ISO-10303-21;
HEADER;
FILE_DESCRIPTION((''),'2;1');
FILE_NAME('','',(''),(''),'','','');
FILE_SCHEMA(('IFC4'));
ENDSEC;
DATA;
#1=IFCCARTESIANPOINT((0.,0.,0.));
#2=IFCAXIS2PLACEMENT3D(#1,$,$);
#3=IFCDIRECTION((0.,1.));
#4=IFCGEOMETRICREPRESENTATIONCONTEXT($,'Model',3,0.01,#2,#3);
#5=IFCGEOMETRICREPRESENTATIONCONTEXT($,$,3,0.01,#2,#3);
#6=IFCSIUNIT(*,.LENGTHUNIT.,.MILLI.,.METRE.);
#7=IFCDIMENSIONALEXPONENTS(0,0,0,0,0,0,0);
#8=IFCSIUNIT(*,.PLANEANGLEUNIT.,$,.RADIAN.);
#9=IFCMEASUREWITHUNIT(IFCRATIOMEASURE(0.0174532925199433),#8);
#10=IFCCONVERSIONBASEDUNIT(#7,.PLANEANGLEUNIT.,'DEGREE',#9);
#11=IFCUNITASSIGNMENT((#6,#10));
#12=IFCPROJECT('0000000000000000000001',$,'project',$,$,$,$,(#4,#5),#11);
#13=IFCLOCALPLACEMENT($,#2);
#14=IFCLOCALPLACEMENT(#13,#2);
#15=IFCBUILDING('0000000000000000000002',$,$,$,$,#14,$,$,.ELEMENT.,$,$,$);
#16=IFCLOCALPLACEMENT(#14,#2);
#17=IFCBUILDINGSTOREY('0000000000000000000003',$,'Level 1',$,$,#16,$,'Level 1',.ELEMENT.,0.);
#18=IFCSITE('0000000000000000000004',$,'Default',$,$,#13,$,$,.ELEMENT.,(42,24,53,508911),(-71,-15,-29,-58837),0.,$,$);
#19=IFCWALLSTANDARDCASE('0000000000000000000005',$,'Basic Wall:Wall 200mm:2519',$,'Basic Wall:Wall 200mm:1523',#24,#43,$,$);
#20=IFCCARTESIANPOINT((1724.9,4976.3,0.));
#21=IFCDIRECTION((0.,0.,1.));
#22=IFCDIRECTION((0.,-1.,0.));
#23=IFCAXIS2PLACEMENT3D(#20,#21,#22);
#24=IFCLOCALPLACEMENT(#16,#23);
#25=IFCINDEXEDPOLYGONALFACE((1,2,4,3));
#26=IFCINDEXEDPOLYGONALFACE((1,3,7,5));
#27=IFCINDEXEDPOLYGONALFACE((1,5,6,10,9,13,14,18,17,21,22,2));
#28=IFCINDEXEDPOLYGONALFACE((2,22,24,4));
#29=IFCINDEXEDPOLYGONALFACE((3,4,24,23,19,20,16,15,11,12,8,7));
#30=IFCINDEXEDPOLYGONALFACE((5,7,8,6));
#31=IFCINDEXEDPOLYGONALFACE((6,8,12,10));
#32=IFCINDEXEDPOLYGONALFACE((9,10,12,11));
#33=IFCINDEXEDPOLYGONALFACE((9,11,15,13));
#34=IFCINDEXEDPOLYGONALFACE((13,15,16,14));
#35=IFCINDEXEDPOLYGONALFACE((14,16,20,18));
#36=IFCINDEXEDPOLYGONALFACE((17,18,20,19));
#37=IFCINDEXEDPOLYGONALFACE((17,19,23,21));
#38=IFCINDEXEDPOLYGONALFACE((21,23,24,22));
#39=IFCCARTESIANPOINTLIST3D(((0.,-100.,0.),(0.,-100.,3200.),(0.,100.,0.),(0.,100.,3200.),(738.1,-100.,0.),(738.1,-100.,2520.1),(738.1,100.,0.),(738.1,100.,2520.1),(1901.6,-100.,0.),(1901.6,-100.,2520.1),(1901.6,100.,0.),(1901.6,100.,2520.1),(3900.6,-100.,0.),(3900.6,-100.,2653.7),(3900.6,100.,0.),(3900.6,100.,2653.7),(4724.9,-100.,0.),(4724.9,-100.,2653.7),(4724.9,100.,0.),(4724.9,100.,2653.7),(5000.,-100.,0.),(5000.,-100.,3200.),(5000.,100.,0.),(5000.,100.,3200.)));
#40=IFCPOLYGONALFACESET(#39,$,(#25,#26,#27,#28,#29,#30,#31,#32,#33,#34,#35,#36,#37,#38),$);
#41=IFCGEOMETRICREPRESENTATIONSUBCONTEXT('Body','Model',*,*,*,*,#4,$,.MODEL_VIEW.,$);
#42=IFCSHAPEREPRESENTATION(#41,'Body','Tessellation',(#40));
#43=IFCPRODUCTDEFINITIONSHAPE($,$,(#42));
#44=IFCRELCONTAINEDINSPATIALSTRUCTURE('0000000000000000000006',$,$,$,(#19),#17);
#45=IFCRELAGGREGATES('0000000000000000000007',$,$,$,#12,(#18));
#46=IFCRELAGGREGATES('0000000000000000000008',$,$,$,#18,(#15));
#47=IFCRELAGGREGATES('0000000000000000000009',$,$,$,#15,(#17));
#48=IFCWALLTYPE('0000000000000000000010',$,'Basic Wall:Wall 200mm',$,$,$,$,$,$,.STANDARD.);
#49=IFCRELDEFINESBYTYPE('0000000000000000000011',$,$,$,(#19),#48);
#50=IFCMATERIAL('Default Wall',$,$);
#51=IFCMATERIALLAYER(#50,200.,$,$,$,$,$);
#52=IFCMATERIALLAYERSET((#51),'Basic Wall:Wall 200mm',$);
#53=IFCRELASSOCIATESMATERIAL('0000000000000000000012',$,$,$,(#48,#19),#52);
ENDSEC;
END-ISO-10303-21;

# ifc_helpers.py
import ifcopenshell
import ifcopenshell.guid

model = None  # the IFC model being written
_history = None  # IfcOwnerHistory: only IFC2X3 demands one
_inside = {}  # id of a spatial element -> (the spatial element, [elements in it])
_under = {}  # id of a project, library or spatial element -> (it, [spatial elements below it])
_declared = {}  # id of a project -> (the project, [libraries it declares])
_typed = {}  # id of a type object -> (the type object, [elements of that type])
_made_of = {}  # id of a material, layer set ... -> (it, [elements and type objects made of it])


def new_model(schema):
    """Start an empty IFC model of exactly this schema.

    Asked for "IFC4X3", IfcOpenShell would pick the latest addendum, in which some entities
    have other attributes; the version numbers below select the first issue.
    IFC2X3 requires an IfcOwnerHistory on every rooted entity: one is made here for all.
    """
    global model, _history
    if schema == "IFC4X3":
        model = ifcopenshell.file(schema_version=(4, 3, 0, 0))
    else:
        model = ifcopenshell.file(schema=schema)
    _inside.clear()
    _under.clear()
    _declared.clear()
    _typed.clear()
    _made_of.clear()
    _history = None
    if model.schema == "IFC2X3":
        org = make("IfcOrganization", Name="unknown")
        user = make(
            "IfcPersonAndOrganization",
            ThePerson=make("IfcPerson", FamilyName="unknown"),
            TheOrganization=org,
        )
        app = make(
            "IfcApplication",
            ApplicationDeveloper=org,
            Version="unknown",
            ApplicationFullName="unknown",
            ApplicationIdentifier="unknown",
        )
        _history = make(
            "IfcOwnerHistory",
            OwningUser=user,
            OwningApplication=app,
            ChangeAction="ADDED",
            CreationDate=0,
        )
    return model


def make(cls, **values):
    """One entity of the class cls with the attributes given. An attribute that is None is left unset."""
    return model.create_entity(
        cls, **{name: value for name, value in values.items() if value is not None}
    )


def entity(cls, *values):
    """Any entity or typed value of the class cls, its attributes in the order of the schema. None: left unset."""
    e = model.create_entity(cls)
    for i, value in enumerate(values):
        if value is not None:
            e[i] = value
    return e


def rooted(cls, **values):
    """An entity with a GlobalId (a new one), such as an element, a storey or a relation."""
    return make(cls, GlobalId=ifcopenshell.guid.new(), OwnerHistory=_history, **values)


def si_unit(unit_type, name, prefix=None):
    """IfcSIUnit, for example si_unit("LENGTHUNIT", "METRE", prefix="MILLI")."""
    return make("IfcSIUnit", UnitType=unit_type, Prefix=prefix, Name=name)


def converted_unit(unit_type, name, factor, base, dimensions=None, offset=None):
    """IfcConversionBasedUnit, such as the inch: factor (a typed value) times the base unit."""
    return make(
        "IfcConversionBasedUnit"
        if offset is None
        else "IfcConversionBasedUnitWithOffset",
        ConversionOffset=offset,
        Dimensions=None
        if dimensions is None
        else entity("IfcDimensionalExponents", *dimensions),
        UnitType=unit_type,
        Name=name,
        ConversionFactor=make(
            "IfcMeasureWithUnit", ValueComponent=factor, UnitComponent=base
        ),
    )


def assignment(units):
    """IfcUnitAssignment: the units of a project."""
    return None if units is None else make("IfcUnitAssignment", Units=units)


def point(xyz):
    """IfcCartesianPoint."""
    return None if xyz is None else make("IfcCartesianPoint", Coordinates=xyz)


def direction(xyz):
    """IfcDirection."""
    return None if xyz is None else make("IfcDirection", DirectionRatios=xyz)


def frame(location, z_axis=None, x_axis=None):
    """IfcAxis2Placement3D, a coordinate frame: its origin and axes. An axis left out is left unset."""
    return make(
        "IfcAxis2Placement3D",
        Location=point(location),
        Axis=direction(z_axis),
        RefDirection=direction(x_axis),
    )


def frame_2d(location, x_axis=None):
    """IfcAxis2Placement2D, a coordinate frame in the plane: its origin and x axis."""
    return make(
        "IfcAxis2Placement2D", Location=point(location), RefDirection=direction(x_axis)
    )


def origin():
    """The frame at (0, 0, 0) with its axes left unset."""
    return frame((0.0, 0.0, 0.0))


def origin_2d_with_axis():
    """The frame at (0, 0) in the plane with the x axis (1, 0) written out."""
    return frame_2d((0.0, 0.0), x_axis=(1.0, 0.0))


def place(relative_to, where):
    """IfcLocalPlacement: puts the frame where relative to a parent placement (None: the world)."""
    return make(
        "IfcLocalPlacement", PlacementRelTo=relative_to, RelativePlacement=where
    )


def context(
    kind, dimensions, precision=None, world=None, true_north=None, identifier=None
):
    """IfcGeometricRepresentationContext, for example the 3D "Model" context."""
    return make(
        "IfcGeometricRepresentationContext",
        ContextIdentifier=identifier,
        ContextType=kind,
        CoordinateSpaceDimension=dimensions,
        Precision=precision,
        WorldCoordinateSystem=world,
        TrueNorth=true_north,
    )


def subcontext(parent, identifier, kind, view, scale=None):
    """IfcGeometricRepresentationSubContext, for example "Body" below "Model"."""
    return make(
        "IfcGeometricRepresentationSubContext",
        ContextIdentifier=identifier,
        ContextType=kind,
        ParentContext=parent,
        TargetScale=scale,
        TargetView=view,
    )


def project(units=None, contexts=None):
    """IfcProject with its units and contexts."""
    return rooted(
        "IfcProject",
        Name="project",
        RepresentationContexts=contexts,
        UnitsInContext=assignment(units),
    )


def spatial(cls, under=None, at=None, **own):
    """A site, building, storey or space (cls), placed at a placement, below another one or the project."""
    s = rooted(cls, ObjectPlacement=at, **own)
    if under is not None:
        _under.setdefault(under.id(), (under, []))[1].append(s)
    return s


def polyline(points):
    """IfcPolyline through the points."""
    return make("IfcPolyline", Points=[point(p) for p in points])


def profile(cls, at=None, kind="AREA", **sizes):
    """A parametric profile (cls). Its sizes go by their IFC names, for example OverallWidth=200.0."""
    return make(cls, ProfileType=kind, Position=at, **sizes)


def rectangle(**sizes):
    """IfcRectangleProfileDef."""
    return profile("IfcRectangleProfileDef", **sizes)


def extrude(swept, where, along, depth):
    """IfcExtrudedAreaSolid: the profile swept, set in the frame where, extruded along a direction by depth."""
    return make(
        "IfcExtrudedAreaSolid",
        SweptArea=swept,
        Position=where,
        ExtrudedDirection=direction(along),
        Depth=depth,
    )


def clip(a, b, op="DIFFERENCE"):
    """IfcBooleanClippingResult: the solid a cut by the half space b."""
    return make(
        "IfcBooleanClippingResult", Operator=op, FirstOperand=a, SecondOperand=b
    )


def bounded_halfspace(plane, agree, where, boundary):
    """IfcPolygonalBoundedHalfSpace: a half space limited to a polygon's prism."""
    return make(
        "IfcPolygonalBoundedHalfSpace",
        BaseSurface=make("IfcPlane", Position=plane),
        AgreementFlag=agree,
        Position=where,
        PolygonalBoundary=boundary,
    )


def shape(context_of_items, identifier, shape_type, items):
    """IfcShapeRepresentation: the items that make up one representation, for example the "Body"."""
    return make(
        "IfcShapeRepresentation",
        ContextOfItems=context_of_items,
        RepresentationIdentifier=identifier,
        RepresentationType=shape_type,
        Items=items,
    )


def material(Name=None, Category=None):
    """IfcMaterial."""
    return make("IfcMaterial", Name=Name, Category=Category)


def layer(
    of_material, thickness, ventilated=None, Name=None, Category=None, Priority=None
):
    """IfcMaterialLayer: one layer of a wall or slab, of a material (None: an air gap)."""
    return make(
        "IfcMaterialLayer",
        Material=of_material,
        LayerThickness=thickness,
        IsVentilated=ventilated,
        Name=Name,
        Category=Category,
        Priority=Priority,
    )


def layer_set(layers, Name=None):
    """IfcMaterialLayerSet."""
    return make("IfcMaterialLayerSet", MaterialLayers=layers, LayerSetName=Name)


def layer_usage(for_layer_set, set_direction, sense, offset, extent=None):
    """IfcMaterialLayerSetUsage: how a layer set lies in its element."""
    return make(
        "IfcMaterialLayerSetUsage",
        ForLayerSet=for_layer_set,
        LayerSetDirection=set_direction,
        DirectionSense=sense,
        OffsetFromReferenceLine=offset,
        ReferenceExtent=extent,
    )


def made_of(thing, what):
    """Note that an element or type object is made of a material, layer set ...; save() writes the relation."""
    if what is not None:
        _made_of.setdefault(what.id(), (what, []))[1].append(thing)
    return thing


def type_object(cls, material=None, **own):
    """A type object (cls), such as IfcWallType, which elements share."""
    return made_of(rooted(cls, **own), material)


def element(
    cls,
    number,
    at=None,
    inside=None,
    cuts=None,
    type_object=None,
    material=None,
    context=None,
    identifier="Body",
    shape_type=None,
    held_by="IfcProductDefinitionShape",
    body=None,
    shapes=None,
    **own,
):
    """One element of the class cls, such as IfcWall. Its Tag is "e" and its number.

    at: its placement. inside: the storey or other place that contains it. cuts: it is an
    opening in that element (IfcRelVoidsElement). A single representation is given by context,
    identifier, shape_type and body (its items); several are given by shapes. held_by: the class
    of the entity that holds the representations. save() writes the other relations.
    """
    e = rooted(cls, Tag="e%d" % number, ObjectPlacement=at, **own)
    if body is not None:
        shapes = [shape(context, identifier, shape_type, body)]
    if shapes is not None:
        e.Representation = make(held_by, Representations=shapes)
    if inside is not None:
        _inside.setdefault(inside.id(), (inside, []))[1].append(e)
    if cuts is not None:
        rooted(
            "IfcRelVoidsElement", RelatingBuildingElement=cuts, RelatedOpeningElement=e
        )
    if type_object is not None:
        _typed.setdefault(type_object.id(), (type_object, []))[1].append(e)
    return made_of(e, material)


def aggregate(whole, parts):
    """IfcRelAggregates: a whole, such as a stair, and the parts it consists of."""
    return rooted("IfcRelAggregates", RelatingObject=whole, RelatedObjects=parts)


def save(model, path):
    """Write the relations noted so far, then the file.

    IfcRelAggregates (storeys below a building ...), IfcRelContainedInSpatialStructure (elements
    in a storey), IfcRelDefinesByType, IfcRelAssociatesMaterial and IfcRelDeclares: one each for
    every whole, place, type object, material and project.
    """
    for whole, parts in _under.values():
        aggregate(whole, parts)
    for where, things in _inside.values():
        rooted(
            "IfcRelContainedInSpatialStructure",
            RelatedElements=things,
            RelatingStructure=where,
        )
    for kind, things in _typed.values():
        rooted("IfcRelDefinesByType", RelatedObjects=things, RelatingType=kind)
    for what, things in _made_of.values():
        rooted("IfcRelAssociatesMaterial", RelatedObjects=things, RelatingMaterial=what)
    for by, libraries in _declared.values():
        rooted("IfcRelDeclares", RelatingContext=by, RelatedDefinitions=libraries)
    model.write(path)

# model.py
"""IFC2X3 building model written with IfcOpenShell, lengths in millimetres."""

from ifc_helpers import new_model, entity, si_unit, converted_unit, direction, frame, frame_2d, origin, origin_2d_with_axis, place, context, subcontext, project, spatial, polyline, rectangle, extrude, clip, bounded_halfspace, material, layer, layer_set, layer_usage, type_object, element, save


model = new_model("IFC2X3")

# Units and contexts
model_context = context("Model", 3, precision=0.01, world=origin(), true_north=direction((0.0, 1.0)))
context_of_model = context(None, 3, precision=0.01, world=origin(), true_north=direction((0.0, 1.0)))
body_context = subcontext(model_context, "Body", "Model", "MODEL_VIEW")
ifc_project = project(units=[si_unit("LENGTHUNIT", "METRE", prefix="MILLI"), converted_unit("PLANEANGLEUNIT", "DEGREE", entity("IfcRatioMeasure", 0.0174532925199433), si_unit("PLANEANGLEUNIT", "RADIAN"), dimensions=[0, 0, 0, 0, 0, 0, 0])], contexts=[model_context, context_of_model])

# Site, building, storey
site_placement = place(None, origin())
site = spatial("IfcSite", under=ifc_project, at=site_placement, Name="Default", CompositionType="ELEMENT", RefLatitude=(42, 24, 53, 508911), RefLongitude=(-71, -15, -29, -58837), RefElevation=0.0)
building_placement = place(site_placement, origin())
building = spatial("IfcBuilding", under=site, at=building_placement, CompositionType="ELEMENT")
storey_placement = place(building_placement, origin())
storey = spatial("IfcBuildingStorey", under=building, at=storey_placement, Name="Level 1", LongName="Level 1", CompositionType="ELEMENT", Elevation=0.0)

# Shared definitions
ifc_material_1 = material(Name="Default Wall")
ifc_layer_1 = layer(ifc_material_1, 200.0)
ifc_layer_set_1 = layer_set([ifc_layer_1], Name="Basic Wall:Wall 200mm")
wall_type = type_object("IfcWallType", Name="Basic Wall:Wall 200mm", PredefinedType="STANDARD", material=ifc_layer_set_1)

# Wall, openings
ifc_layer_usage_1 = layer_usage(ifc_layer_set_1, "AXIS2", "NEGATIVE", 100.0)
wall_1_placement = place(storey_placement, frame((1724.9, 4976.3, 0.0), z_axis=(0.0, 0.0, 1.0), x_axis=(0.0, -1.0, 0.0)))
wall_1 = element("IfcWallStandardCase", 1, at=wall_1_placement, inside=storey, type_object=wall_type, material=ifc_layer_usage_1, Name="Basic Wall:Wall 200mm:2519", ObjectType="Basic Wall:Wall 200mm:1523", context=body_context, shape_type="Clipping", body=[
    clip(extrude(rectangle(XDim=5000.0, YDim=200.0, at=frame_2d((2500.0, 0.0), x_axis=(-1.0, 0.0))), origin(), (0.0, 0.0, 1.0), 3200.0), bounded_halfspace(frame((0.0, -100.0, 3200.0), z_axis=(0.0, 0.0, -1.0), x_axis=(0.0, 1.0, 0.0)), True, frame((0.0, -100.0, 3200.0)), polyline([(0.0, 0.0), (3004.8, 0.0), (3204.8, 0.0), (5000.0, 0.0), (5000.0, 200.0), (0.0, 200.0), (0.0, 0.0)]))),
])
opening_1_placement = place(wall_1_placement, origin())
element("IfcOpeningElement", 2, at=opening_1_placement, cuts=wall_1, ObjectType="Opening", context=body_context, shape_type="SweptSolid", body=[
    extrude(rectangle(XDim=2611.6, YDim=1163.5, at=origin_2d_with_axis()), frame((1319.8, -100.0, 1214.3), z_axis=(0.0, 1.0, 0.0), x_axis=(0.0, 0.0, -1.0)), (0.0, 0.0, 1.0), 200.0),
])
opening_2_placement = place(wall_1_placement, origin())
element("IfcOpeningElement", 3, at=opening_2_placement, cuts=wall_1, ObjectType="Opening", context=body_context, shape_type="SweptSolid", body=[
    extrude(rectangle(XDim=2688.4, YDim=824.4, at=frame_2d((0.0, 0.0), x_axis=(1.0, 0.0))), frame((4312.7, -100.0, 1309.5), z_axis=(0.0, 1.0, 0.0), x_axis=(0.0, 0.0, -1.0)), (0.0, 0.0, 1.0), 200.0),
])

save(model, "model.ifc")
